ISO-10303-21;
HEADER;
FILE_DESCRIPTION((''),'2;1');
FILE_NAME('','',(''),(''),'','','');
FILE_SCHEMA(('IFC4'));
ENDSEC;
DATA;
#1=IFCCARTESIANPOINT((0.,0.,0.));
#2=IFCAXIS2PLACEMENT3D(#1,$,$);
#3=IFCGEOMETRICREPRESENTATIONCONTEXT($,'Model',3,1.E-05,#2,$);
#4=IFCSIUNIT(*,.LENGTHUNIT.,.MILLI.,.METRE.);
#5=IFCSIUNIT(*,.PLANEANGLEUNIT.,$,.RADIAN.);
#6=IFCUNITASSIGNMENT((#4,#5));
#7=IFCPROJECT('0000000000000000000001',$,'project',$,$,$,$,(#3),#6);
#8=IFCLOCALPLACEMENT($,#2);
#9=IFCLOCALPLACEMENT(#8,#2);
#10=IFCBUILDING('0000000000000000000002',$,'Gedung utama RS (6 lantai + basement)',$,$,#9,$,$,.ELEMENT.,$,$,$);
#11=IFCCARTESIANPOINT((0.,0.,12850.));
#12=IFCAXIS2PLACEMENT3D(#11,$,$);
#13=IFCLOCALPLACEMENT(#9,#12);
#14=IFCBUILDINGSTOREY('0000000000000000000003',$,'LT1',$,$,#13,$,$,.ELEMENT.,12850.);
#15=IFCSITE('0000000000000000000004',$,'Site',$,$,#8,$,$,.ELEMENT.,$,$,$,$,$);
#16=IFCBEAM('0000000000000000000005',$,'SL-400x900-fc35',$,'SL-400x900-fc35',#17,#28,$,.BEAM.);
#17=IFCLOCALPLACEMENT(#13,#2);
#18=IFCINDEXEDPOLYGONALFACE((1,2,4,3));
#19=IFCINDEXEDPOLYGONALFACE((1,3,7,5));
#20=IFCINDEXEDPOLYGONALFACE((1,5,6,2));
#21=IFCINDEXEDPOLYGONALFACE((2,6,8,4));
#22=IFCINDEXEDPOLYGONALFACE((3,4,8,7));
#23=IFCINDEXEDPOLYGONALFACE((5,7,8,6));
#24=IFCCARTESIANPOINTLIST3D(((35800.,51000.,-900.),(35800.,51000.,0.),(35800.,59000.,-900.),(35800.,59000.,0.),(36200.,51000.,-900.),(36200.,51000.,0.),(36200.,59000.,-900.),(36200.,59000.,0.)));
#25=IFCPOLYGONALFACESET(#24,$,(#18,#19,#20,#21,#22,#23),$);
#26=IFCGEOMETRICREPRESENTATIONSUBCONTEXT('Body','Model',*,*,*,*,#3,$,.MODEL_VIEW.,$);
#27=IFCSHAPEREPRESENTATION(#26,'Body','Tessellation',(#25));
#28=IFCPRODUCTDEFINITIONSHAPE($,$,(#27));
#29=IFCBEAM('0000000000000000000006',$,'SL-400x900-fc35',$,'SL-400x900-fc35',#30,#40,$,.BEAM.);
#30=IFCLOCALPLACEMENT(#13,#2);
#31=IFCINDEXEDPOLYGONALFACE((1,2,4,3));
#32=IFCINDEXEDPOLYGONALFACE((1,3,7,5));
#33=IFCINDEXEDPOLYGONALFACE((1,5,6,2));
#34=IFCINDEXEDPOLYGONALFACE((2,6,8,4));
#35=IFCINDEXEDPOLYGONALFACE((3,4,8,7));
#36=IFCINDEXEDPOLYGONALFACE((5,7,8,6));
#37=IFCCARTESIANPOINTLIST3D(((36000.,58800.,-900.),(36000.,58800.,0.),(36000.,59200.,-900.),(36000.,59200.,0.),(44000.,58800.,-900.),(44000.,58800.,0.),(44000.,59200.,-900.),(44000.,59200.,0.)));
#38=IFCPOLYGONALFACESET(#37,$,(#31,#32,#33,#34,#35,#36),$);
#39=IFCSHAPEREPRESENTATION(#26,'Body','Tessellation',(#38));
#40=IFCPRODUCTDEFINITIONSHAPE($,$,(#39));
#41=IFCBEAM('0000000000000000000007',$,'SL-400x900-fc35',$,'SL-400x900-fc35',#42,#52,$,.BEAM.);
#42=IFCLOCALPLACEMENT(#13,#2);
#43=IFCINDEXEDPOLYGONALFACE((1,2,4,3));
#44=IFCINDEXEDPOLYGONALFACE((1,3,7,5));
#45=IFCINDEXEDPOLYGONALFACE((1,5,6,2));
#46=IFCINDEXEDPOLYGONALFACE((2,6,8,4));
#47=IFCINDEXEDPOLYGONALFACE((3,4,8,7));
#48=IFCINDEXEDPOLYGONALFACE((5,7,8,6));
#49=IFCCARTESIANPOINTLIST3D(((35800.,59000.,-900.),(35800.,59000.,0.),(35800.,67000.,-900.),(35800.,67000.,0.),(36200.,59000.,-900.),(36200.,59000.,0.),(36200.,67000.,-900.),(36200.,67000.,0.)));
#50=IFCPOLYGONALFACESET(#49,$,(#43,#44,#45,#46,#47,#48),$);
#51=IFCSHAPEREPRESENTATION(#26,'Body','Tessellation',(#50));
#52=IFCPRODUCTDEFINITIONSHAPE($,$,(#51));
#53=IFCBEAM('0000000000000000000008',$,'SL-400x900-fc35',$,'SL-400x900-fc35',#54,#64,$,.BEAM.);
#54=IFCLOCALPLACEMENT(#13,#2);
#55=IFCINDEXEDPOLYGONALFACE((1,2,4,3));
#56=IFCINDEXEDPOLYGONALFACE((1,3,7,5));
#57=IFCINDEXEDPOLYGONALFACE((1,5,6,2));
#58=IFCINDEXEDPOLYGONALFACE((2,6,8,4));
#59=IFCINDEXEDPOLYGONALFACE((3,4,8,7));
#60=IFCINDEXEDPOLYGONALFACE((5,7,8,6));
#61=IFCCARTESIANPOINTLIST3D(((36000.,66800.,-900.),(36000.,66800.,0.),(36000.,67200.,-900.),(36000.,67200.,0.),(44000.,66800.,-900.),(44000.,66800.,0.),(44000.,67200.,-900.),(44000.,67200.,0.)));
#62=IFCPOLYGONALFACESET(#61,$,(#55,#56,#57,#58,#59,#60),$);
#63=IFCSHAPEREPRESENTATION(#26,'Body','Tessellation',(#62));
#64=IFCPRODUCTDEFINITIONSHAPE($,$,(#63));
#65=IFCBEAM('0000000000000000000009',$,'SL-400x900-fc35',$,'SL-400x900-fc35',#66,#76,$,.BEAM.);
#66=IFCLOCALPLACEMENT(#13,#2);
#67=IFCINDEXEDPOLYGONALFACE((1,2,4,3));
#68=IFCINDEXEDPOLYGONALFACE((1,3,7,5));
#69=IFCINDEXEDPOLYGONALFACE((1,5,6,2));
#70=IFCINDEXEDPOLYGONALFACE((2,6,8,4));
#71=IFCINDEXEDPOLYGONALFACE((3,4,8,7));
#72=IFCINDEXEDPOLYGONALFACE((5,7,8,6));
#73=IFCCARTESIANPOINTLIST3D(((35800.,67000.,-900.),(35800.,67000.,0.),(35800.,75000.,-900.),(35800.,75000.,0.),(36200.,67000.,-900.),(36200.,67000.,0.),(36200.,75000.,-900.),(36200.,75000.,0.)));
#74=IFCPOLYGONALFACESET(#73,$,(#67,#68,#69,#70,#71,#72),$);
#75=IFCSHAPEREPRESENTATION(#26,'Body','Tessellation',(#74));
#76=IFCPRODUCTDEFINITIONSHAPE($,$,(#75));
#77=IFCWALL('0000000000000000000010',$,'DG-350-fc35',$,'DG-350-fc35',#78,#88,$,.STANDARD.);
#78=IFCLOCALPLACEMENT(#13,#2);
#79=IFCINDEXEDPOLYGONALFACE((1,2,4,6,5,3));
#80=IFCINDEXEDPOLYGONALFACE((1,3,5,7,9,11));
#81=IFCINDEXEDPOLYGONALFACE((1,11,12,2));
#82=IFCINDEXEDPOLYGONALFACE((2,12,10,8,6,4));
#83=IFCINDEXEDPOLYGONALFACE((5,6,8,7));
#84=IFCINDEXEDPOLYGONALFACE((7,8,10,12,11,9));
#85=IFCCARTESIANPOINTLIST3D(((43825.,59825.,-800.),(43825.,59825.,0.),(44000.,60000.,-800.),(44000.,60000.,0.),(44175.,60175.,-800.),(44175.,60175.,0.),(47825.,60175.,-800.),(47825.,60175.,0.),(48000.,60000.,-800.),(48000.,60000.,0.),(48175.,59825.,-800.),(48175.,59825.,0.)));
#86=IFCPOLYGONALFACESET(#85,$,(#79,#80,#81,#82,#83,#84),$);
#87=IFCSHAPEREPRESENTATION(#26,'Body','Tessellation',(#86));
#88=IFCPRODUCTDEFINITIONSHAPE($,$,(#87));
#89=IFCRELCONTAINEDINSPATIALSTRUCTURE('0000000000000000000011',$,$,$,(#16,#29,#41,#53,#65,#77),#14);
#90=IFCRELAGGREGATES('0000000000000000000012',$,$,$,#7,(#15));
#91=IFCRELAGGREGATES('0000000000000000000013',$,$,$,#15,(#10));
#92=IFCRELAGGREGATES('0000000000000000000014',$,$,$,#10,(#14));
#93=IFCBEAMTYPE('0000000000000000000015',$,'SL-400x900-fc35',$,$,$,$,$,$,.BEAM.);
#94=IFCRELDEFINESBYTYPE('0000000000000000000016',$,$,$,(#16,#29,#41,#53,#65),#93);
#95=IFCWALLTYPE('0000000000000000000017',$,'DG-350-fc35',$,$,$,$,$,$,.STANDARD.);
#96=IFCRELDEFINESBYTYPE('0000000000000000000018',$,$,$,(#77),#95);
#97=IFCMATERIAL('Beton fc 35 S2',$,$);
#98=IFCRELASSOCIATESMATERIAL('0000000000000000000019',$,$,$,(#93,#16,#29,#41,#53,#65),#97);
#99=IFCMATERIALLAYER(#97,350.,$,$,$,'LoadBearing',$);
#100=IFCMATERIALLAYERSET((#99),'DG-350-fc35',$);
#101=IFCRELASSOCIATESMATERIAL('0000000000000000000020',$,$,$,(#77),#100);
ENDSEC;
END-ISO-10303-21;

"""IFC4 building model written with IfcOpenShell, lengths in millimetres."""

from ifc_helpers import new_model, si_unit, frame, origin, origin_2d, place, context, subcontext, project, spatial, polyline, rectangle, outline, extrude, material, layer, layer_set, layer_usage, material_profile, profile_set, profile_usage, type_object, element, save


model = new_model("IFC4")

# Units and contexts
model_context = context("Model", 3, precision=1e-05, world=origin())
body_context = subcontext(model_context, "Body", "Model", "MODEL_VIEW")
ifc_project = project(units=[si_unit("LENGTHUNIT", "METRE", prefix="MILLI"), si_unit("PLANEANGLEUNIT", "RADIAN")], contexts=[model_context])

# Site, building, storey
site_placement = place(None, origin())
site = spatial("IfcSite", under=ifc_project, at=site_placement, Name="Site", CompositionType="ELEMENT")
building_placement = place(site_placement, origin())
building = spatial("IfcBuilding", under=site, at=building_placement, Name="Gedung utama RS (6 lantai + basement)", CompositionType="ELEMENT")
storey_placement = place(building_placement, frame((0.0, 0.0, 12850.0)))
storey = spatial("IfcBuildingStorey", under=building, at=storey_placement, Name="LT1", CompositionType="ELEMENT", Elevation=12850.0)

# Beams
ifc_material = material(Name="Beton fc 35 S2")
ifc_material_profile_1 = material_profile(ifc_material, rectangle(XDim=400.0, YDim=900.0, at=origin_2d()), Name="SL-400x900-fc35")
ifc_profile_set_1 = profile_set([ifc_material_profile_1], Name="SL-400x900-fc35")
ifc_profile_usage_1 = profile_usage(ifc_profile_set_1, cardinal=8)
beam_type_1 = type_object("IfcBeamType", Name="SL-400x900-fc35", PredefinedType="BEAM", material=ifc_profile_set_1)
beam_1_placement = place(storey_placement, frame((36000.0, 51000.0, -450.0)))
element("IfcBeam", 1, at=beam_1_placement, inside=storey, type_object=beam_type_1, material=ifc_profile_usage_1, Name="SL-400x900-fc35", ObjectType="SL-400x900-fc35", PredefinedType="BEAM", context=body_context, shape_type="SweptSolid", body=[
    extrude(rectangle(XDim=400.0, YDim=900.0, at=origin_2d()), frame((0.0, 0.0, 0.0), z_axis=(0.0, 1.0, 0.0), x_axis=(-1.0, 0.0, 0.0)), (0.0, 0.0, 1.0), 8000.0),
])
beam_2_placement = place(storey_placement, frame((36000.0, 59000.0, -450.0)))
element("IfcBeam", 2, at=beam_2_placement, inside=storey, type_object=beam_type_1, material=ifc_profile_usage_1, Name="SL-400x900-fc35", ObjectType="SL-400x900-fc35", PredefinedType="BEAM", context=body_context, shape_type="SweptSolid", body=[
    extrude(rectangle(XDim=400.0, YDim=900.0, at=origin_2d()), frame((0.0, 0.0, 0.0), z_axis=(1.0, 0.0, 0.0), x_axis=(0.0, 1.0, 0.0)), (0.0, 0.0, 1.0), 8000.0),
])
beam_3_placement = place(storey_placement, frame((36000.0, 59000.0, -450.0)))
element("IfcBeam", 3, at=beam_3_placement, inside=storey, type_object=beam_type_1, material=ifc_profile_usage_1, Name="SL-400x900-fc35", ObjectType="SL-400x900-fc35", PredefinedType="BEAM", context=body_context, shape_type="SweptSolid", body=[
    extrude(rectangle(XDim=400.0, YDim=900.0, at=origin_2d()), frame((0.0, 0.0, 0.0), z_axis=(0.0, 1.0, 0.0), x_axis=(-1.0, 0.0, 0.0)), (0.0, 0.0, 1.0), 8000.0),
])
beam_4_placement = place(storey_placement, frame((36000.0, 67000.0, -450.0)))
element("IfcBeam", 4, at=beam_4_placement, inside=storey, type_object=beam_type_1, material=ifc_profile_usage_1, Name="SL-400x900-fc35", ObjectType="SL-400x900-fc35", PredefinedType="BEAM", context=body_context, shape_type="SweptSolid", body=[
    extrude(rectangle(XDim=400.0, YDim=900.0, at=origin_2d()), frame((0.0, 0.0, 0.0), z_axis=(1.0, 0.0, 0.0), x_axis=(0.0, 1.0, 0.0)), (0.0, 0.0, 1.0), 8000.0),
])
beam_5_placement = place(storey_placement, frame((36000.0, 67000.0, -450.0)))
element("IfcBeam", 5, at=beam_5_placement, inside=storey, type_object=beam_type_1, material=ifc_profile_usage_1, Name="SL-400x900-fc35", ObjectType="SL-400x900-fc35", PredefinedType="BEAM", context=body_context, shape_type="SweptSolid", body=[
    extrude(rectangle(XDim=400.0, YDim=900.0, at=origin_2d()), frame((0.0, 0.0, 0.0), z_axis=(0.0, 1.0, 0.0), x_axis=(-1.0, 0.0, 0.0)), (0.0, 0.0, 1.0), 8000.0),
])

# Wall
ifc_layer = layer(ifc_material, 350.0, Category="LoadBearing")
ifc_layer_set = layer_set([ifc_layer], Name="DG-350-fc35")
ifc_layer_usage = layer_usage(ifc_layer_set, "AXIS2", "NEGATIVE", 175.0)
wall_type = type_object("IfcWallType", Name="DG-350-fc35", PredefinedType="STANDARD")
wall_placement = place(storey_placement, frame((44000.0, 60000.0, -800.0), z_axis=(0.0, 0.0, 1.0), x_axis=(1.0, 0.0, 0.0)))
element("IfcWall", 6, at=wall_placement, inside=storey, type_object=wall_type, material=ifc_layer_usage, Name="DG-350-fc35", ObjectType="DG-350-fc35", PredefinedType="STANDARD", context=body_context, shape_type="SweptSolid", body=[
    extrude(outline(polyline([(-175.0, -175.0), (0.0, 0.0), (175.0, 175.0), (3825.0, 175.0), (4000.0, 0.0), (4175.0, -175.0), (-175.0, -175.0)])), origin(), (0.0, 0.0, 1.0), 800.0),
])

save(model, "model.ifc")
